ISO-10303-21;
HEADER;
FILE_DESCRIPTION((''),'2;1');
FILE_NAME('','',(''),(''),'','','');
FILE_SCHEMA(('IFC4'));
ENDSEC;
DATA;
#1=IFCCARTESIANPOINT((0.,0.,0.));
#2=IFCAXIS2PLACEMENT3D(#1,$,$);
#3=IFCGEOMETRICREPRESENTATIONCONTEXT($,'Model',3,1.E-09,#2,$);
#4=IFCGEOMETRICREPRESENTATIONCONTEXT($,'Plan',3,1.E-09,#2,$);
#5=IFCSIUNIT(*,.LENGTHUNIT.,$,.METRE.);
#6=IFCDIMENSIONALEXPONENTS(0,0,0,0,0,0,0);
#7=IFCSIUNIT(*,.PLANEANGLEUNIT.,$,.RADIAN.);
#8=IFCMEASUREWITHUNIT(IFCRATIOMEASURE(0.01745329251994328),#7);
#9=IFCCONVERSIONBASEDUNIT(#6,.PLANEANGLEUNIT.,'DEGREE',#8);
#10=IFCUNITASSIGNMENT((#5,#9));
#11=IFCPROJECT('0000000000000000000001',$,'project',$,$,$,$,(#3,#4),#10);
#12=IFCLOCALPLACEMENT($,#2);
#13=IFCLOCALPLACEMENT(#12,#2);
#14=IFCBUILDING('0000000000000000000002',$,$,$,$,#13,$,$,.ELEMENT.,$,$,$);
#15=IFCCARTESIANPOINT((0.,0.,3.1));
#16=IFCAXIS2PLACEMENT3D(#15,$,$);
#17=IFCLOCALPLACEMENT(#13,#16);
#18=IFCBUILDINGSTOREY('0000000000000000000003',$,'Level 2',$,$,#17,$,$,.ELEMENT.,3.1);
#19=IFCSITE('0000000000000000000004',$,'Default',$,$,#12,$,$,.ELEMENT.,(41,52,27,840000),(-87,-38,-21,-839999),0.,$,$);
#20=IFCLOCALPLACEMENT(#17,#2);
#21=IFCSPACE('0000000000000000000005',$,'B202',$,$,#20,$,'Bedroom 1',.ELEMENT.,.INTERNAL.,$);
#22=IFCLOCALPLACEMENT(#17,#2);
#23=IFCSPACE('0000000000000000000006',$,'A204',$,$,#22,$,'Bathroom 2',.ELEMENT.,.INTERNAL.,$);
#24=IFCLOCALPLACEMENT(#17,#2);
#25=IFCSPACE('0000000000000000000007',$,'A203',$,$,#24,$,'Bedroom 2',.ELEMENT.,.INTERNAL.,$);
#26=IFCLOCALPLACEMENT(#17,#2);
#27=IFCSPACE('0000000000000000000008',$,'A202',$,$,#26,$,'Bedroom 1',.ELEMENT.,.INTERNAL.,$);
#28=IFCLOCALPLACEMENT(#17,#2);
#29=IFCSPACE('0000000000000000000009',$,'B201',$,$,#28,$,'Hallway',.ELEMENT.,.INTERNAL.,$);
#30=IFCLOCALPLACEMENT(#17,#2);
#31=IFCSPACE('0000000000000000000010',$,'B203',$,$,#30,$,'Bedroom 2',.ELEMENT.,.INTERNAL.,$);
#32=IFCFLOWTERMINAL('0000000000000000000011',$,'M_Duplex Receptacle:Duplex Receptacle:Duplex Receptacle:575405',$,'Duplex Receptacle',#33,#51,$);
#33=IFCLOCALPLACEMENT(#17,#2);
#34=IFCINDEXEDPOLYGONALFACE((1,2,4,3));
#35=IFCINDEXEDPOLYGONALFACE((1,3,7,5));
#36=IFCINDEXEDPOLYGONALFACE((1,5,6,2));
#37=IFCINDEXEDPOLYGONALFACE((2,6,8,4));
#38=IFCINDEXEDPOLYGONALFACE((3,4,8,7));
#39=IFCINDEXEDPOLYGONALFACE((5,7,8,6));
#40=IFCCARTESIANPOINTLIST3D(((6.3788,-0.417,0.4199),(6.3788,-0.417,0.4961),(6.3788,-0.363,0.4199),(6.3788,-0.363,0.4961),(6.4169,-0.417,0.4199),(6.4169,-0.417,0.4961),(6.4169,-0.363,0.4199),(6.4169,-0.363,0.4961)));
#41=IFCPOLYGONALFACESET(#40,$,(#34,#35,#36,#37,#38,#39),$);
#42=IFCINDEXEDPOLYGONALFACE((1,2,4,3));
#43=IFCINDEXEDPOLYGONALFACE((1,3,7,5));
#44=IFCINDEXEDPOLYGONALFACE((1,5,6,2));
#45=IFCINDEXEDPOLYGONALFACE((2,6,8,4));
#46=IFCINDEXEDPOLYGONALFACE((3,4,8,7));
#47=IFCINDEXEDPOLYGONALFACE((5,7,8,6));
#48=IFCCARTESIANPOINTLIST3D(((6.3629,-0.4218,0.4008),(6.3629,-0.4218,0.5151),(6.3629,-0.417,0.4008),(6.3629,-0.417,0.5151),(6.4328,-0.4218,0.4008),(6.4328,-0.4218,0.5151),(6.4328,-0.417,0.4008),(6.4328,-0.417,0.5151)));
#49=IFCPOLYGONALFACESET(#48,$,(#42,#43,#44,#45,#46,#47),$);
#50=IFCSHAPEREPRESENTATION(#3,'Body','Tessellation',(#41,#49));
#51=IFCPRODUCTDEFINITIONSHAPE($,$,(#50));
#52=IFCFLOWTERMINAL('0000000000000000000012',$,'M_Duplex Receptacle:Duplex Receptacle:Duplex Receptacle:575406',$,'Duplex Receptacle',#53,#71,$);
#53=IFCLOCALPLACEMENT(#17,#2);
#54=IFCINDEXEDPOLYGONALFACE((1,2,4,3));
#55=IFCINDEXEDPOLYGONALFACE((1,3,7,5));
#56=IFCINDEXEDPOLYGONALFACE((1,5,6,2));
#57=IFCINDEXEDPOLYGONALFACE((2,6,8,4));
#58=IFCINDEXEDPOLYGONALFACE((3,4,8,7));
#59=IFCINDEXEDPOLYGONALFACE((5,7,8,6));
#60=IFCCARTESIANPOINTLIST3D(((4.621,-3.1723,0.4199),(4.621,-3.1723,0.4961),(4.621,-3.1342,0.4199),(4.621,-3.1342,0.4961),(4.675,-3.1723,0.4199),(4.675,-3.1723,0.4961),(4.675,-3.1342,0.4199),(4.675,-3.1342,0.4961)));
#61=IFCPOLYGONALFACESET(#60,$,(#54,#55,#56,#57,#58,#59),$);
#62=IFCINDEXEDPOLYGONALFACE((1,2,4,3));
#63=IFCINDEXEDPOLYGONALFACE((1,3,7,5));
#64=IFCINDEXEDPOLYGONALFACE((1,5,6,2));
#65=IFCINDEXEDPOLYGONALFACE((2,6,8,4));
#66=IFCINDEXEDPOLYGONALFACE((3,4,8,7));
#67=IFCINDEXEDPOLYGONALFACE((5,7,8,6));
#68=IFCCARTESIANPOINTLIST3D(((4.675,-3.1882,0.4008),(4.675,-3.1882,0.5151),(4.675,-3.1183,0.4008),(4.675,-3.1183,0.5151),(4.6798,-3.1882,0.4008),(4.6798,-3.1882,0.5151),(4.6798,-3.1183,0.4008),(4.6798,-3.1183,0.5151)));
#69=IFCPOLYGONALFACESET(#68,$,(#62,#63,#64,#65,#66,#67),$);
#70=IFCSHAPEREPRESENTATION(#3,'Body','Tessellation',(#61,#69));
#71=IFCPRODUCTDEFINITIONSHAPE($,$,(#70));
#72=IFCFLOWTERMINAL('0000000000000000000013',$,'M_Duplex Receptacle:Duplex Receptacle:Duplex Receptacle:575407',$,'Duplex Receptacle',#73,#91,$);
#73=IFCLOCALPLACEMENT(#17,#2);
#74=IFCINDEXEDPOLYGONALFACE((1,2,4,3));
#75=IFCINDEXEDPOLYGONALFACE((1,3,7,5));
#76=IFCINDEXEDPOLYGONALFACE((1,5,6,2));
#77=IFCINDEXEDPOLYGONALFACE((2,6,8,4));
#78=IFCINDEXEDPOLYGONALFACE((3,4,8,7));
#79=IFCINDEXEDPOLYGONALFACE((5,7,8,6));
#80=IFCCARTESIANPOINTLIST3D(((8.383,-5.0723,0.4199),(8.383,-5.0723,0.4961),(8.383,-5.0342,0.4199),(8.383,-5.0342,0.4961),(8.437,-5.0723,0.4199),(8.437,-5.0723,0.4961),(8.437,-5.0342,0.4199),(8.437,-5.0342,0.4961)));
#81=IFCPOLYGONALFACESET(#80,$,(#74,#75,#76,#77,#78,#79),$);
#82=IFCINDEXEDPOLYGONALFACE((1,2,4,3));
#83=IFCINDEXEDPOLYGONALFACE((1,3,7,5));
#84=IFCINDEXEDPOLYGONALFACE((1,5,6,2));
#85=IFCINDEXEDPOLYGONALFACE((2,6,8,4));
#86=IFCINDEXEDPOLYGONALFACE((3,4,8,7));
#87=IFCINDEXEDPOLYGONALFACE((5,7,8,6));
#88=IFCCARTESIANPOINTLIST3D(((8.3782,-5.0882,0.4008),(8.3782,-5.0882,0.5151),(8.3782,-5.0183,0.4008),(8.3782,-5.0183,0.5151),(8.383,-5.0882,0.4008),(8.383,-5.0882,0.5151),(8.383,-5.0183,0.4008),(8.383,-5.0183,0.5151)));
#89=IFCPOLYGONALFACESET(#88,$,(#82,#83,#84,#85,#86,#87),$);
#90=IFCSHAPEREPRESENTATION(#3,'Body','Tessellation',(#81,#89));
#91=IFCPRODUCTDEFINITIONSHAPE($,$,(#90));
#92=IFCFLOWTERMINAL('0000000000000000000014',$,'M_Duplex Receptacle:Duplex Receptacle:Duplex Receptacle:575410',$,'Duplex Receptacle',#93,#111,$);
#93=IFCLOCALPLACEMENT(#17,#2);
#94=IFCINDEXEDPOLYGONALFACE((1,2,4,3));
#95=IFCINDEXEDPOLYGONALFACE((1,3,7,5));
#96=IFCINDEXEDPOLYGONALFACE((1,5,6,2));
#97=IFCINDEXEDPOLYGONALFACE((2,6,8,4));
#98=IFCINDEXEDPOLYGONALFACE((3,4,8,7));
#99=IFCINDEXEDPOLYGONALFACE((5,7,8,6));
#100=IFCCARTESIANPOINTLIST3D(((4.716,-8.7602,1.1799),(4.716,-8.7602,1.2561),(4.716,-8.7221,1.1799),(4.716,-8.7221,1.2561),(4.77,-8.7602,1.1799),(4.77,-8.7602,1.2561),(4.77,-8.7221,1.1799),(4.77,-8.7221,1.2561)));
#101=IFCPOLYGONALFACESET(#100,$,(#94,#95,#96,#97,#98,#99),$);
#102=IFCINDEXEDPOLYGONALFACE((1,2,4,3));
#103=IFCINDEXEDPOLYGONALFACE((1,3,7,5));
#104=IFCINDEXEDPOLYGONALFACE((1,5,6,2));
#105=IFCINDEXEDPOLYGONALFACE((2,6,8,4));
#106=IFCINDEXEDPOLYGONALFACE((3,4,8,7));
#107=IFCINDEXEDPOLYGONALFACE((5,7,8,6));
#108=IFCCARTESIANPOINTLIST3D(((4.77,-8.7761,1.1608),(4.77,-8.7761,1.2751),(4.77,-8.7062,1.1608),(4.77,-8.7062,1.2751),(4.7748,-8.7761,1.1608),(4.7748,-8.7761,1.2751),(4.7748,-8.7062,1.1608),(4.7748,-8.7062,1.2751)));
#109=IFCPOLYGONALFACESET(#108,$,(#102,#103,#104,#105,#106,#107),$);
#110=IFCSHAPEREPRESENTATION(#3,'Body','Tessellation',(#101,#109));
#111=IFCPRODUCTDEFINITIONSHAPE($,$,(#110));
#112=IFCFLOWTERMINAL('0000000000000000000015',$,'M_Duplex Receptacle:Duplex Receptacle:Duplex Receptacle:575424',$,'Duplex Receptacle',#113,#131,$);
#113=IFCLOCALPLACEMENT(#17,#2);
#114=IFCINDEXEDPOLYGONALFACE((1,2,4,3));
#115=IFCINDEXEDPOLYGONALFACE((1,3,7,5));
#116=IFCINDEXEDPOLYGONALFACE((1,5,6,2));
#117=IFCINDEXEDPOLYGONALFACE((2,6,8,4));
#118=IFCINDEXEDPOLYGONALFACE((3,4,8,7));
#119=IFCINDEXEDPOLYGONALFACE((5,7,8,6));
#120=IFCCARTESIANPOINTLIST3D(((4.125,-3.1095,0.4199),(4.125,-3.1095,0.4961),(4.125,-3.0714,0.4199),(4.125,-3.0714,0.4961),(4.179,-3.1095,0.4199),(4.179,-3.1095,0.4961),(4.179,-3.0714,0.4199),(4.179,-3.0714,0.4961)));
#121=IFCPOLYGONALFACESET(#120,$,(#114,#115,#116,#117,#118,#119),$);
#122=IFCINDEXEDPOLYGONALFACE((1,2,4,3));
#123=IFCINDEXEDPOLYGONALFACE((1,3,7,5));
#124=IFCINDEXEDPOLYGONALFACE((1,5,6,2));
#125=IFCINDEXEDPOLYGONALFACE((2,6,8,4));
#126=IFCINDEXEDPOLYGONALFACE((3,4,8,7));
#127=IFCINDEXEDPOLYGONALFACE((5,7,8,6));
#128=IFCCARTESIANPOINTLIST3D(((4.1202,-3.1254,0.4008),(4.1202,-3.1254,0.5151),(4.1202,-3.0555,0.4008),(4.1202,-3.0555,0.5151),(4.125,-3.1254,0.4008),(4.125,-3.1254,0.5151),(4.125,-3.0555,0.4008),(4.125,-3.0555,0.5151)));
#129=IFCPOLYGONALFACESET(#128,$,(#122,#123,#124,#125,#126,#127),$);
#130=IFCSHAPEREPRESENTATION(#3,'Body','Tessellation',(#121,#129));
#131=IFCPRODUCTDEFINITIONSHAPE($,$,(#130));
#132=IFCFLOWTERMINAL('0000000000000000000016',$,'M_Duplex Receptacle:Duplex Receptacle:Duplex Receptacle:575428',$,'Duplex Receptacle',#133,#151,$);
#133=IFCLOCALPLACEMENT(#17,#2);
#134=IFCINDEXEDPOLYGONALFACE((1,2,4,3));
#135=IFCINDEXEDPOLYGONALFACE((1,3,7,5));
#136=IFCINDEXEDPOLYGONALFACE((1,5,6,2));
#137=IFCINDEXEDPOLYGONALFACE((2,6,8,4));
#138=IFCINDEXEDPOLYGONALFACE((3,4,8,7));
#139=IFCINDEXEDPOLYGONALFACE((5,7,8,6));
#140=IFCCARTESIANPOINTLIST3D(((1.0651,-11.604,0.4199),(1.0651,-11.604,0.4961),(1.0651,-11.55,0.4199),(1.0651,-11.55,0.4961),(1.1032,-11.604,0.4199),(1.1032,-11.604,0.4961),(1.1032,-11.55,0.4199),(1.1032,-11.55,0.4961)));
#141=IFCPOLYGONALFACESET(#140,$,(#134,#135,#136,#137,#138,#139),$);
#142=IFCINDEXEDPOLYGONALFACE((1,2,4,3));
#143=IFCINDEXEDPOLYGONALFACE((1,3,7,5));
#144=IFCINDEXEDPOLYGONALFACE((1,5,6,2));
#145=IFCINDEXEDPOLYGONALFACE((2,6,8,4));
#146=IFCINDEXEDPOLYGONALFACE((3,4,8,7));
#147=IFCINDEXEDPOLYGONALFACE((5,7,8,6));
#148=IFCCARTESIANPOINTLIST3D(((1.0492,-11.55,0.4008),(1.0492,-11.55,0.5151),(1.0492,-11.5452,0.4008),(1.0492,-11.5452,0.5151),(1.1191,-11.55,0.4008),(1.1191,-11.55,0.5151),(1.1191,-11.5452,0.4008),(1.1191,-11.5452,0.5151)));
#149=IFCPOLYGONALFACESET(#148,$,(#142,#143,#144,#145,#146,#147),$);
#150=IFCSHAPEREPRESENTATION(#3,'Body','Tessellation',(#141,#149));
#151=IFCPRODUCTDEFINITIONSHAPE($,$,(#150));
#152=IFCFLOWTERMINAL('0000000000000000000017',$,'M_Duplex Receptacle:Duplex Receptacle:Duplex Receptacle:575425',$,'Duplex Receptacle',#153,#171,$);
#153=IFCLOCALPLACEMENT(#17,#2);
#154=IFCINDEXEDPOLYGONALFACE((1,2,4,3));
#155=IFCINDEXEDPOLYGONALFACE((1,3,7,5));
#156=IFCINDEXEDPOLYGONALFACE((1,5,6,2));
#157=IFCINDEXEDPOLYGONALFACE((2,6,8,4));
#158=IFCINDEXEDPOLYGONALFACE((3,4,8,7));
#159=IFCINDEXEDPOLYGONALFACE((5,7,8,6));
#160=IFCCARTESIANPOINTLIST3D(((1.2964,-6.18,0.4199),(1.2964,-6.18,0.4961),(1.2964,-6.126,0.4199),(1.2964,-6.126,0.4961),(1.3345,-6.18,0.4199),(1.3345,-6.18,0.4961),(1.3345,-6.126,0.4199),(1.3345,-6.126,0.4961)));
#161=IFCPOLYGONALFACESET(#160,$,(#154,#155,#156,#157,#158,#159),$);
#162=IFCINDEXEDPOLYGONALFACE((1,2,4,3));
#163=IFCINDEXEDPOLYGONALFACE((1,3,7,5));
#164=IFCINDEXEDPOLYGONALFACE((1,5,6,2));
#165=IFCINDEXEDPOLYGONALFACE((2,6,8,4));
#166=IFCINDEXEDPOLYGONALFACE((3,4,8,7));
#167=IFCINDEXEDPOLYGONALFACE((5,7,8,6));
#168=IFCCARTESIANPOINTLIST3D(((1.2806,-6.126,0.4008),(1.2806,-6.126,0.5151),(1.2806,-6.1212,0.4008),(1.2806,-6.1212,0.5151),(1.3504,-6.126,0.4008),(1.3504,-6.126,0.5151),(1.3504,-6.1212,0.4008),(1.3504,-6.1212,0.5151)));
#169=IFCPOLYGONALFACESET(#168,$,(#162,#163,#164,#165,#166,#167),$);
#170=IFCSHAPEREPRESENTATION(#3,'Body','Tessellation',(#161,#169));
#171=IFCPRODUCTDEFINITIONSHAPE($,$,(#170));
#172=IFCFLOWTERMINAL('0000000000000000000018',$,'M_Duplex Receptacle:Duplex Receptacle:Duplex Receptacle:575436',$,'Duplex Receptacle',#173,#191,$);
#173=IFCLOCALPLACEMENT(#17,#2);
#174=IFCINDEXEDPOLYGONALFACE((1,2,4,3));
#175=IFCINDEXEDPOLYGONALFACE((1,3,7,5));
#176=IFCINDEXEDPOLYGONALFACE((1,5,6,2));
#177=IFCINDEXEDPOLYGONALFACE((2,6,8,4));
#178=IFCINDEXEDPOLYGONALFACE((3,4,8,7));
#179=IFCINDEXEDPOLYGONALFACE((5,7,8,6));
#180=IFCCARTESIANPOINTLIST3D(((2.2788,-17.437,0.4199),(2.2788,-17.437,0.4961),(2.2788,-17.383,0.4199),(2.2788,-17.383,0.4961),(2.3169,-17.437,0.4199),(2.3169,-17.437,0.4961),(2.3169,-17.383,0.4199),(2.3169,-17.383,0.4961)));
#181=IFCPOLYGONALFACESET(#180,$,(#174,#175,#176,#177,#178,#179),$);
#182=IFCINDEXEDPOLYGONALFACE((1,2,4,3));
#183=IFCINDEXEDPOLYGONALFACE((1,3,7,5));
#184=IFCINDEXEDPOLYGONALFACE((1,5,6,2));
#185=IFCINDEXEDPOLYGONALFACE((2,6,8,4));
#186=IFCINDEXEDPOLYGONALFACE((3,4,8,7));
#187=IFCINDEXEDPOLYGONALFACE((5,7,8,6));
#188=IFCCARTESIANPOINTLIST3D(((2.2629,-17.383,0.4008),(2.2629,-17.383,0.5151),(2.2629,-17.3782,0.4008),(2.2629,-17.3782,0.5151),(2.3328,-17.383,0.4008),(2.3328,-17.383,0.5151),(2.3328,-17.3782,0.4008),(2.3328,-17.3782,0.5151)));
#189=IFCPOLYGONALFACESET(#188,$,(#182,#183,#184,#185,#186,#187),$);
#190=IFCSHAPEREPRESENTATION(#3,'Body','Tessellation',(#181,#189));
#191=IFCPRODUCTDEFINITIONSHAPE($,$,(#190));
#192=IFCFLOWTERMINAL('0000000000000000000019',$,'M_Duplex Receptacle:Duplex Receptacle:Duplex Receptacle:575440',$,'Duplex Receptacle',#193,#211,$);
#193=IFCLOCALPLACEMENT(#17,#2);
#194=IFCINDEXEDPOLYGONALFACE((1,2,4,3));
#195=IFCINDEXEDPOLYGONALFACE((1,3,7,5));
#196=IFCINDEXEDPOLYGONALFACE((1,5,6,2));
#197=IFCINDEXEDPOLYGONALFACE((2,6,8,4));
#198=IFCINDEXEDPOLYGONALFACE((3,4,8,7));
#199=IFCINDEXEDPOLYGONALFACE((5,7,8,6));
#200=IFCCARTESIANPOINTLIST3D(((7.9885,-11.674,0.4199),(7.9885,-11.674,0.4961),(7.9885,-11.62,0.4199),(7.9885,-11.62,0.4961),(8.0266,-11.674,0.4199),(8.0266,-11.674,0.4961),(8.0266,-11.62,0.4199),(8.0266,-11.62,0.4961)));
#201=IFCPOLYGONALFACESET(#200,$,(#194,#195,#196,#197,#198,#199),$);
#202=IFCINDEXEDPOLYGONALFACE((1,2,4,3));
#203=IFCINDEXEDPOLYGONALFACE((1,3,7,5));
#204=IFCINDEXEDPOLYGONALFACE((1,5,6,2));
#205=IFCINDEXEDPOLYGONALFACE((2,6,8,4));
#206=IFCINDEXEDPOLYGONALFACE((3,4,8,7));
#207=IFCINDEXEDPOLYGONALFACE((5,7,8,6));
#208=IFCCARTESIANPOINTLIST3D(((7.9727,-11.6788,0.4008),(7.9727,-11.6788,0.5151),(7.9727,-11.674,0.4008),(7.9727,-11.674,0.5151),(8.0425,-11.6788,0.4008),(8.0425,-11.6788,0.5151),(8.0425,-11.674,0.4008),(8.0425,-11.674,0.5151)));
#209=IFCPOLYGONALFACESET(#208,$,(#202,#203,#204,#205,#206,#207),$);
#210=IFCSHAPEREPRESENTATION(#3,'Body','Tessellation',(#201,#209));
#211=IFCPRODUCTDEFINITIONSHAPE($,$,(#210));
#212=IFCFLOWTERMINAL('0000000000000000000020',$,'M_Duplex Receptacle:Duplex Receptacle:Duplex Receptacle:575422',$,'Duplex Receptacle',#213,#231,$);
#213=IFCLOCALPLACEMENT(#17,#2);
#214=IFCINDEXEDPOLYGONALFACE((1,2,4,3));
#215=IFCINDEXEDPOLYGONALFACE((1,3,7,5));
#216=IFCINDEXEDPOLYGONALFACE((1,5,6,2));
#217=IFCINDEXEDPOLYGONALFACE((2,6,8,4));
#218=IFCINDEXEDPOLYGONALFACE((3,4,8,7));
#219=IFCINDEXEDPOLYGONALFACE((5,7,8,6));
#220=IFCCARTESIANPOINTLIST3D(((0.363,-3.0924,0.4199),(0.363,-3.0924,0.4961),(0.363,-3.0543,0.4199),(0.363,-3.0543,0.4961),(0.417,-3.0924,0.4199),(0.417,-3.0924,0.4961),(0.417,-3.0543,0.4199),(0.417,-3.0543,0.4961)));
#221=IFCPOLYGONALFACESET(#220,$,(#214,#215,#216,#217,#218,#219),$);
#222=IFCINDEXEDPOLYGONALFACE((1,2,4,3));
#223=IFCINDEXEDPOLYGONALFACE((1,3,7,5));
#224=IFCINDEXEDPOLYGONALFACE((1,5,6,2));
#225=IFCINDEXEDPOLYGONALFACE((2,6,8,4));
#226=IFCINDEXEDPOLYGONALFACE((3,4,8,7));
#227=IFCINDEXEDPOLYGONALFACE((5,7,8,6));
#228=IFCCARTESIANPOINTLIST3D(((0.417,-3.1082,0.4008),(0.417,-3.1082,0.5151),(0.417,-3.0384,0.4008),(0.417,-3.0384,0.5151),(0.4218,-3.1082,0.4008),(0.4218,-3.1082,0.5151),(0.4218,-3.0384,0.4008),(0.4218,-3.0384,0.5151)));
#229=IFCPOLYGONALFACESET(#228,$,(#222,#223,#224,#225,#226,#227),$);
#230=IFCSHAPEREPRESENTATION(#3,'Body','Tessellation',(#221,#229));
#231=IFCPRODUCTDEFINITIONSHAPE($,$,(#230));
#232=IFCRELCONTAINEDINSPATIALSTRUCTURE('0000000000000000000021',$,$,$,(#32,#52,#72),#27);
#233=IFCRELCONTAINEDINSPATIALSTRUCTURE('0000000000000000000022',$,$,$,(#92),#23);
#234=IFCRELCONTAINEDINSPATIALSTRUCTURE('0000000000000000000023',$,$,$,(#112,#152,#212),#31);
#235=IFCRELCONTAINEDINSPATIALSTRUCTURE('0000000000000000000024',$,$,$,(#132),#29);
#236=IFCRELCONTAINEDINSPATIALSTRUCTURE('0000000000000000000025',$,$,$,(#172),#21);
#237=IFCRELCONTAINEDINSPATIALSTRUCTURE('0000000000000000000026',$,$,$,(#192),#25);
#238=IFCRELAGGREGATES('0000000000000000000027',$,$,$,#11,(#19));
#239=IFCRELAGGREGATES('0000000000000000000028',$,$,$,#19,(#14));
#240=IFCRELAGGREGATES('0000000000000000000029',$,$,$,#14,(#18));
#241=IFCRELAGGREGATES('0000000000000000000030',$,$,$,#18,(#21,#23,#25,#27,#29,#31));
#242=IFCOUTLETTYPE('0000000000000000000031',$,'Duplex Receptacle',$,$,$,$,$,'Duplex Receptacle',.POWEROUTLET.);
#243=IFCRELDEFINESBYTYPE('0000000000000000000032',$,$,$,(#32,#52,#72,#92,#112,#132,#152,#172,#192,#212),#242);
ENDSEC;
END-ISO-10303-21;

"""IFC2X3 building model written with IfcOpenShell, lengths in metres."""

from ifc_helpers import new_model, entity, si_unit, converted_unit, frame, origin, origin_2d_with_axis, place, context, project, spatial, rectangle, extrude, source, transform, mapped, type_object, type_shapes, element, save


model = new_model("IFC2X3")

# Units and contexts
model_context = context("Model", 3, precision=1e-09, world=origin())
plan_context = context("Plan", 3, precision=1e-09, world=origin())
ifc_project = project(units=[si_unit("LENGTHUNIT", "METRE"), converted_unit("PLANEANGLEUNIT", "DEGREE", entity("IfcRatioMeasure", 0.01745329251994328), si_unit("PLANEANGLEUNIT", "RADIAN"), dimensions=[0, 0, 0, 0, 0, 0, 0])], contexts=[model_context, plan_context])

# Site, building, storey, space
site_placement = place(None, origin())
site = spatial("IfcSite", under=ifc_project, at=site_placement, Name="Default", CompositionType="ELEMENT", RefLatitude=(41, 52, 27, 840000), RefLongitude=(-87, -38, -21, -839999), RefElevation=0.0)
building_placement = place(site_placement, origin())
building = spatial("IfcBuilding", under=site, at=building_placement, CompositionType="ELEMENT")
storey_placement = place(building_placement, frame((0.0, 0.0, 3.1)))
storey = spatial("IfcBuildingStorey", under=building, at=storey_placement, Name="Level 2", CompositionType="ELEMENT", Elevation=3.1)
space_1_placement = place(storey_placement, origin())
space_1 = spatial("IfcSpace", under=storey, at=space_1_placement, Name="B202", LongName="Bedroom 1", CompositionType="ELEMENT", InteriorOrExteriorSpace="INTERNAL")

# Shared definitions
shared_shape_1 = source(origin(), model_context, "Body", "SweptSolid", [
    extrude(rectangle(XDim=0.0381, YDim=0.0762, at=origin_2d_with_axis()), frame((0.0, 0.0, -0.054), z_axis=(0.0, 0.0, 1.0), x_axis=(-1.0, 0.0, 0.0)), (0.0, 0.0, 1.0), 0.054),
    extrude(rectangle(XDim=0.0698, YDim=0.1143, at=origin_2d_with_axis()), frame((0.0, 0.0, 0.0), z_axis=(0.0, 0.0, 1.0), x_axis=(-1.0, 0.0, 0.0)), (0.0, 0.0, 1.0), 0.0048),
])

# Shared definitions
space_2_placement = place(storey_placement, origin())
space_2 = spatial("IfcSpace", under=storey, at=space_2_placement, Name="A204", LongName="Bathroom 2", CompositionType="ELEMENT", InteriorOrExteriorSpace="INTERNAL")

# Shared definitions
space_3_placement = place(storey_placement, origin())
space_3 = spatial("IfcSpace", under=storey, at=space_3_placement, Name="A203", LongName="Bedroom 2", CompositionType="ELEMENT", InteriorOrExteriorSpace="INTERNAL")

# Shared definitions
space_4_placement = place(storey_placement, origin())
space_4 = spatial("IfcSpace", under=storey, at=space_4_placement, Name="A202", LongName="Bedroom 1", CompositionType="ELEMENT", InteriorOrExteriorSpace="INTERNAL")

# Shared definitions
space_5_placement = place(storey_placement, origin())
space_5 = spatial("IfcSpace", under=storey, at=space_5_placement, Name="B201", LongName="Hallway", CompositionType="ELEMENT", InteriorOrExteriorSpace="INTERNAL")

# Shared definitions
space_6_placement = place(storey_placement, origin())
space_6 = spatial("IfcSpace", under=storey, at=space_6_placement, Name="B203", LongName="Bedroom 2", CompositionType="ELEMENT", InteriorOrExteriorSpace="INTERNAL")

# Flow terminals
outlet_type = type_object("IfcOutletType", Name="Duplex Receptacle", ElementType="Duplex Receptacle", PredefinedType="POWEROUTLET")
type_shapes(outlet_type, [shared_shape_1])
for number, where, z_axis, x_axis, name in (
    (1, (6.3979, -0.417, 0.458), (0.0, -1.0, 0.0), (1.0, 0.0, 0.0), "M_Duplex Receptacle:Duplex Receptacle:Duplex Receptacle:575405"),
    (2, (4.675, -3.1533, 0.458), (1.0, 0.0, 0.0), (0.0, 1.0, 0.0), "M_Duplex Receptacle:Duplex Receptacle:Duplex Receptacle:575406"),
    (3, (8.383, -5.0533, 0.458), (-1.0, 0.0, 0.0), (0.0, -1.0, 0.0), "M_Duplex Receptacle:Duplex Receptacle:Duplex Receptacle:575407"),
):
    element("IfcFlowTerminal", number, at=place(space_4_placement, frame(where, z_axis=z_axis, x_axis=x_axis)), inside=space_4, type_object=outlet_type, Name=name, ObjectType="Duplex Receptacle", context=model_context, shape_type="MappedRepresentation", body=[
        mapped(shared_shape_1, transform((0.0, 0.0, 0.0), scale=1.0)),
    ])
flow_terminal_1_placement = place(space_2_placement, frame((4.77, -8.7412, 1.218), z_axis=(1.0, 0.0, 0.0), x_axis=(0.0, 1.0, 0.0)))
element("IfcFlowTerminal", 4, at=flow_terminal_1_placement, inside=space_2, type_object=outlet_type, Name="M_Duplex Receptacle:Duplex Receptacle:Duplex Receptacle:575410", ObjectType="Duplex Receptacle", context=model_context, shape_type="MappedRepresentation", body=[
    mapped(shared_shape_1, transform((0.0, 0.0, 0.0), scale=1.0)),
])
flow_terminal_2_placement = place(space_6_placement, frame((4.125, -3.0905, 0.458), z_axis=(-1.0, 0.0, 0.0), x_axis=(0.0, -1.0, 0.0)))
element("IfcFlowTerminal", 5, at=flow_terminal_2_placement, inside=space_6, type_object=outlet_type, Name="M_Duplex Receptacle:Duplex Receptacle:Duplex Receptacle:575424", ObjectType="Duplex Receptacle", context=model_context, shape_type="MappedRepresentation", body=[
    mapped(shared_shape_1, transform((0.0, 0.0, 0.0), scale=1.0)),
])
flow_terminal_3_placement = place(space_5_placement, frame((1.0841, -11.55, 0.458), z_axis=(0.0, 1.0, 0.0), x_axis=(-1.0, 0.0, 0.0)))
element("IfcFlowTerminal", 6, at=flow_terminal_3_placement, inside=space_5, type_object=outlet_type, Name="M_Duplex Receptacle:Duplex Receptacle:Duplex Receptacle:575428", ObjectType="Duplex Receptacle", context=model_context, shape_type="MappedRepresentation", body=[
    mapped(shared_shape_1, transform((0.0, 0.0, 0.0), scale=1.0)),
])
flow_terminal_4_placement = place(space_6_placement, frame((1.3155, -6.126, 0.458), z_axis=(0.0, 1.0, 0.0), x_axis=(-1.0, 0.0, 0.0)))
element("IfcFlowTerminal", 7, at=flow_terminal_4_placement, inside=space_6, type_object=outlet_type, Name="M_Duplex Receptacle:Duplex Receptacle:Duplex Receptacle:575425", ObjectType="Duplex Receptacle", context=model_context, shape_type="MappedRepresentation", body=[
    mapped(shared_shape_1, transform((0.0, 0.0, 0.0), scale=1.0)),
])
flow_terminal_5_placement = place(space_1_placement, frame((2.2979, -17.383, 0.458), z_axis=(0.0, 1.0, 0.0), x_axis=(-1.0, 0.0, 0.0)))
element("IfcFlowTerminal", 8, at=flow_terminal_5_placement, inside=space_1, type_object=outlet_type, Name="M_Duplex Receptacle:Duplex Receptacle:Duplex Receptacle:575436", ObjectType="Duplex Receptacle", context=model_context, shape_type="MappedRepresentation", body=[
    mapped(shared_shape_1, transform((0.0, 0.0, 0.0), scale=1.0)),
])
flow_terminal_6_placement = place(space_3_placement, frame((8.0076, -11.674, 0.458), z_axis=(0.0, -1.0, 0.0), x_axis=(1.0, 0.0, 0.0)))
element("IfcFlowTerminal", 9, at=flow_terminal_6_placement, inside=space_3, type_object=outlet_type, Name="M_Duplex Receptacle:Duplex Receptacle:Duplex Receptacle:575440", ObjectType="Duplex Receptacle", context=model_context, shape_type="MappedRepresentation", body=[
    mapped(shared_shape_1, transform((0.0, 0.0, 0.0), scale=1.0)),
])
flow_terminal_7_placement = place(space_6_placement, frame((0.417, -3.0733, 0.458), z_axis=(1.0, 0.0, 0.0), x_axis=(0.0, 1.0, 0.0)))
element("IfcFlowTerminal", 10, at=flow_terminal_7_placement, inside=space_6, type_object=outlet_type, Name="M_Duplex Receptacle:Duplex Receptacle:Duplex Receptacle:575422", ObjectType="Duplex Receptacle", context=model_context, shape_type="MappedRepresentation", body=[
    mapped(shared_shape_1, transform((0.0, 0.0, 0.0), scale=1.0)),
])

save(model, "model.ifc")
